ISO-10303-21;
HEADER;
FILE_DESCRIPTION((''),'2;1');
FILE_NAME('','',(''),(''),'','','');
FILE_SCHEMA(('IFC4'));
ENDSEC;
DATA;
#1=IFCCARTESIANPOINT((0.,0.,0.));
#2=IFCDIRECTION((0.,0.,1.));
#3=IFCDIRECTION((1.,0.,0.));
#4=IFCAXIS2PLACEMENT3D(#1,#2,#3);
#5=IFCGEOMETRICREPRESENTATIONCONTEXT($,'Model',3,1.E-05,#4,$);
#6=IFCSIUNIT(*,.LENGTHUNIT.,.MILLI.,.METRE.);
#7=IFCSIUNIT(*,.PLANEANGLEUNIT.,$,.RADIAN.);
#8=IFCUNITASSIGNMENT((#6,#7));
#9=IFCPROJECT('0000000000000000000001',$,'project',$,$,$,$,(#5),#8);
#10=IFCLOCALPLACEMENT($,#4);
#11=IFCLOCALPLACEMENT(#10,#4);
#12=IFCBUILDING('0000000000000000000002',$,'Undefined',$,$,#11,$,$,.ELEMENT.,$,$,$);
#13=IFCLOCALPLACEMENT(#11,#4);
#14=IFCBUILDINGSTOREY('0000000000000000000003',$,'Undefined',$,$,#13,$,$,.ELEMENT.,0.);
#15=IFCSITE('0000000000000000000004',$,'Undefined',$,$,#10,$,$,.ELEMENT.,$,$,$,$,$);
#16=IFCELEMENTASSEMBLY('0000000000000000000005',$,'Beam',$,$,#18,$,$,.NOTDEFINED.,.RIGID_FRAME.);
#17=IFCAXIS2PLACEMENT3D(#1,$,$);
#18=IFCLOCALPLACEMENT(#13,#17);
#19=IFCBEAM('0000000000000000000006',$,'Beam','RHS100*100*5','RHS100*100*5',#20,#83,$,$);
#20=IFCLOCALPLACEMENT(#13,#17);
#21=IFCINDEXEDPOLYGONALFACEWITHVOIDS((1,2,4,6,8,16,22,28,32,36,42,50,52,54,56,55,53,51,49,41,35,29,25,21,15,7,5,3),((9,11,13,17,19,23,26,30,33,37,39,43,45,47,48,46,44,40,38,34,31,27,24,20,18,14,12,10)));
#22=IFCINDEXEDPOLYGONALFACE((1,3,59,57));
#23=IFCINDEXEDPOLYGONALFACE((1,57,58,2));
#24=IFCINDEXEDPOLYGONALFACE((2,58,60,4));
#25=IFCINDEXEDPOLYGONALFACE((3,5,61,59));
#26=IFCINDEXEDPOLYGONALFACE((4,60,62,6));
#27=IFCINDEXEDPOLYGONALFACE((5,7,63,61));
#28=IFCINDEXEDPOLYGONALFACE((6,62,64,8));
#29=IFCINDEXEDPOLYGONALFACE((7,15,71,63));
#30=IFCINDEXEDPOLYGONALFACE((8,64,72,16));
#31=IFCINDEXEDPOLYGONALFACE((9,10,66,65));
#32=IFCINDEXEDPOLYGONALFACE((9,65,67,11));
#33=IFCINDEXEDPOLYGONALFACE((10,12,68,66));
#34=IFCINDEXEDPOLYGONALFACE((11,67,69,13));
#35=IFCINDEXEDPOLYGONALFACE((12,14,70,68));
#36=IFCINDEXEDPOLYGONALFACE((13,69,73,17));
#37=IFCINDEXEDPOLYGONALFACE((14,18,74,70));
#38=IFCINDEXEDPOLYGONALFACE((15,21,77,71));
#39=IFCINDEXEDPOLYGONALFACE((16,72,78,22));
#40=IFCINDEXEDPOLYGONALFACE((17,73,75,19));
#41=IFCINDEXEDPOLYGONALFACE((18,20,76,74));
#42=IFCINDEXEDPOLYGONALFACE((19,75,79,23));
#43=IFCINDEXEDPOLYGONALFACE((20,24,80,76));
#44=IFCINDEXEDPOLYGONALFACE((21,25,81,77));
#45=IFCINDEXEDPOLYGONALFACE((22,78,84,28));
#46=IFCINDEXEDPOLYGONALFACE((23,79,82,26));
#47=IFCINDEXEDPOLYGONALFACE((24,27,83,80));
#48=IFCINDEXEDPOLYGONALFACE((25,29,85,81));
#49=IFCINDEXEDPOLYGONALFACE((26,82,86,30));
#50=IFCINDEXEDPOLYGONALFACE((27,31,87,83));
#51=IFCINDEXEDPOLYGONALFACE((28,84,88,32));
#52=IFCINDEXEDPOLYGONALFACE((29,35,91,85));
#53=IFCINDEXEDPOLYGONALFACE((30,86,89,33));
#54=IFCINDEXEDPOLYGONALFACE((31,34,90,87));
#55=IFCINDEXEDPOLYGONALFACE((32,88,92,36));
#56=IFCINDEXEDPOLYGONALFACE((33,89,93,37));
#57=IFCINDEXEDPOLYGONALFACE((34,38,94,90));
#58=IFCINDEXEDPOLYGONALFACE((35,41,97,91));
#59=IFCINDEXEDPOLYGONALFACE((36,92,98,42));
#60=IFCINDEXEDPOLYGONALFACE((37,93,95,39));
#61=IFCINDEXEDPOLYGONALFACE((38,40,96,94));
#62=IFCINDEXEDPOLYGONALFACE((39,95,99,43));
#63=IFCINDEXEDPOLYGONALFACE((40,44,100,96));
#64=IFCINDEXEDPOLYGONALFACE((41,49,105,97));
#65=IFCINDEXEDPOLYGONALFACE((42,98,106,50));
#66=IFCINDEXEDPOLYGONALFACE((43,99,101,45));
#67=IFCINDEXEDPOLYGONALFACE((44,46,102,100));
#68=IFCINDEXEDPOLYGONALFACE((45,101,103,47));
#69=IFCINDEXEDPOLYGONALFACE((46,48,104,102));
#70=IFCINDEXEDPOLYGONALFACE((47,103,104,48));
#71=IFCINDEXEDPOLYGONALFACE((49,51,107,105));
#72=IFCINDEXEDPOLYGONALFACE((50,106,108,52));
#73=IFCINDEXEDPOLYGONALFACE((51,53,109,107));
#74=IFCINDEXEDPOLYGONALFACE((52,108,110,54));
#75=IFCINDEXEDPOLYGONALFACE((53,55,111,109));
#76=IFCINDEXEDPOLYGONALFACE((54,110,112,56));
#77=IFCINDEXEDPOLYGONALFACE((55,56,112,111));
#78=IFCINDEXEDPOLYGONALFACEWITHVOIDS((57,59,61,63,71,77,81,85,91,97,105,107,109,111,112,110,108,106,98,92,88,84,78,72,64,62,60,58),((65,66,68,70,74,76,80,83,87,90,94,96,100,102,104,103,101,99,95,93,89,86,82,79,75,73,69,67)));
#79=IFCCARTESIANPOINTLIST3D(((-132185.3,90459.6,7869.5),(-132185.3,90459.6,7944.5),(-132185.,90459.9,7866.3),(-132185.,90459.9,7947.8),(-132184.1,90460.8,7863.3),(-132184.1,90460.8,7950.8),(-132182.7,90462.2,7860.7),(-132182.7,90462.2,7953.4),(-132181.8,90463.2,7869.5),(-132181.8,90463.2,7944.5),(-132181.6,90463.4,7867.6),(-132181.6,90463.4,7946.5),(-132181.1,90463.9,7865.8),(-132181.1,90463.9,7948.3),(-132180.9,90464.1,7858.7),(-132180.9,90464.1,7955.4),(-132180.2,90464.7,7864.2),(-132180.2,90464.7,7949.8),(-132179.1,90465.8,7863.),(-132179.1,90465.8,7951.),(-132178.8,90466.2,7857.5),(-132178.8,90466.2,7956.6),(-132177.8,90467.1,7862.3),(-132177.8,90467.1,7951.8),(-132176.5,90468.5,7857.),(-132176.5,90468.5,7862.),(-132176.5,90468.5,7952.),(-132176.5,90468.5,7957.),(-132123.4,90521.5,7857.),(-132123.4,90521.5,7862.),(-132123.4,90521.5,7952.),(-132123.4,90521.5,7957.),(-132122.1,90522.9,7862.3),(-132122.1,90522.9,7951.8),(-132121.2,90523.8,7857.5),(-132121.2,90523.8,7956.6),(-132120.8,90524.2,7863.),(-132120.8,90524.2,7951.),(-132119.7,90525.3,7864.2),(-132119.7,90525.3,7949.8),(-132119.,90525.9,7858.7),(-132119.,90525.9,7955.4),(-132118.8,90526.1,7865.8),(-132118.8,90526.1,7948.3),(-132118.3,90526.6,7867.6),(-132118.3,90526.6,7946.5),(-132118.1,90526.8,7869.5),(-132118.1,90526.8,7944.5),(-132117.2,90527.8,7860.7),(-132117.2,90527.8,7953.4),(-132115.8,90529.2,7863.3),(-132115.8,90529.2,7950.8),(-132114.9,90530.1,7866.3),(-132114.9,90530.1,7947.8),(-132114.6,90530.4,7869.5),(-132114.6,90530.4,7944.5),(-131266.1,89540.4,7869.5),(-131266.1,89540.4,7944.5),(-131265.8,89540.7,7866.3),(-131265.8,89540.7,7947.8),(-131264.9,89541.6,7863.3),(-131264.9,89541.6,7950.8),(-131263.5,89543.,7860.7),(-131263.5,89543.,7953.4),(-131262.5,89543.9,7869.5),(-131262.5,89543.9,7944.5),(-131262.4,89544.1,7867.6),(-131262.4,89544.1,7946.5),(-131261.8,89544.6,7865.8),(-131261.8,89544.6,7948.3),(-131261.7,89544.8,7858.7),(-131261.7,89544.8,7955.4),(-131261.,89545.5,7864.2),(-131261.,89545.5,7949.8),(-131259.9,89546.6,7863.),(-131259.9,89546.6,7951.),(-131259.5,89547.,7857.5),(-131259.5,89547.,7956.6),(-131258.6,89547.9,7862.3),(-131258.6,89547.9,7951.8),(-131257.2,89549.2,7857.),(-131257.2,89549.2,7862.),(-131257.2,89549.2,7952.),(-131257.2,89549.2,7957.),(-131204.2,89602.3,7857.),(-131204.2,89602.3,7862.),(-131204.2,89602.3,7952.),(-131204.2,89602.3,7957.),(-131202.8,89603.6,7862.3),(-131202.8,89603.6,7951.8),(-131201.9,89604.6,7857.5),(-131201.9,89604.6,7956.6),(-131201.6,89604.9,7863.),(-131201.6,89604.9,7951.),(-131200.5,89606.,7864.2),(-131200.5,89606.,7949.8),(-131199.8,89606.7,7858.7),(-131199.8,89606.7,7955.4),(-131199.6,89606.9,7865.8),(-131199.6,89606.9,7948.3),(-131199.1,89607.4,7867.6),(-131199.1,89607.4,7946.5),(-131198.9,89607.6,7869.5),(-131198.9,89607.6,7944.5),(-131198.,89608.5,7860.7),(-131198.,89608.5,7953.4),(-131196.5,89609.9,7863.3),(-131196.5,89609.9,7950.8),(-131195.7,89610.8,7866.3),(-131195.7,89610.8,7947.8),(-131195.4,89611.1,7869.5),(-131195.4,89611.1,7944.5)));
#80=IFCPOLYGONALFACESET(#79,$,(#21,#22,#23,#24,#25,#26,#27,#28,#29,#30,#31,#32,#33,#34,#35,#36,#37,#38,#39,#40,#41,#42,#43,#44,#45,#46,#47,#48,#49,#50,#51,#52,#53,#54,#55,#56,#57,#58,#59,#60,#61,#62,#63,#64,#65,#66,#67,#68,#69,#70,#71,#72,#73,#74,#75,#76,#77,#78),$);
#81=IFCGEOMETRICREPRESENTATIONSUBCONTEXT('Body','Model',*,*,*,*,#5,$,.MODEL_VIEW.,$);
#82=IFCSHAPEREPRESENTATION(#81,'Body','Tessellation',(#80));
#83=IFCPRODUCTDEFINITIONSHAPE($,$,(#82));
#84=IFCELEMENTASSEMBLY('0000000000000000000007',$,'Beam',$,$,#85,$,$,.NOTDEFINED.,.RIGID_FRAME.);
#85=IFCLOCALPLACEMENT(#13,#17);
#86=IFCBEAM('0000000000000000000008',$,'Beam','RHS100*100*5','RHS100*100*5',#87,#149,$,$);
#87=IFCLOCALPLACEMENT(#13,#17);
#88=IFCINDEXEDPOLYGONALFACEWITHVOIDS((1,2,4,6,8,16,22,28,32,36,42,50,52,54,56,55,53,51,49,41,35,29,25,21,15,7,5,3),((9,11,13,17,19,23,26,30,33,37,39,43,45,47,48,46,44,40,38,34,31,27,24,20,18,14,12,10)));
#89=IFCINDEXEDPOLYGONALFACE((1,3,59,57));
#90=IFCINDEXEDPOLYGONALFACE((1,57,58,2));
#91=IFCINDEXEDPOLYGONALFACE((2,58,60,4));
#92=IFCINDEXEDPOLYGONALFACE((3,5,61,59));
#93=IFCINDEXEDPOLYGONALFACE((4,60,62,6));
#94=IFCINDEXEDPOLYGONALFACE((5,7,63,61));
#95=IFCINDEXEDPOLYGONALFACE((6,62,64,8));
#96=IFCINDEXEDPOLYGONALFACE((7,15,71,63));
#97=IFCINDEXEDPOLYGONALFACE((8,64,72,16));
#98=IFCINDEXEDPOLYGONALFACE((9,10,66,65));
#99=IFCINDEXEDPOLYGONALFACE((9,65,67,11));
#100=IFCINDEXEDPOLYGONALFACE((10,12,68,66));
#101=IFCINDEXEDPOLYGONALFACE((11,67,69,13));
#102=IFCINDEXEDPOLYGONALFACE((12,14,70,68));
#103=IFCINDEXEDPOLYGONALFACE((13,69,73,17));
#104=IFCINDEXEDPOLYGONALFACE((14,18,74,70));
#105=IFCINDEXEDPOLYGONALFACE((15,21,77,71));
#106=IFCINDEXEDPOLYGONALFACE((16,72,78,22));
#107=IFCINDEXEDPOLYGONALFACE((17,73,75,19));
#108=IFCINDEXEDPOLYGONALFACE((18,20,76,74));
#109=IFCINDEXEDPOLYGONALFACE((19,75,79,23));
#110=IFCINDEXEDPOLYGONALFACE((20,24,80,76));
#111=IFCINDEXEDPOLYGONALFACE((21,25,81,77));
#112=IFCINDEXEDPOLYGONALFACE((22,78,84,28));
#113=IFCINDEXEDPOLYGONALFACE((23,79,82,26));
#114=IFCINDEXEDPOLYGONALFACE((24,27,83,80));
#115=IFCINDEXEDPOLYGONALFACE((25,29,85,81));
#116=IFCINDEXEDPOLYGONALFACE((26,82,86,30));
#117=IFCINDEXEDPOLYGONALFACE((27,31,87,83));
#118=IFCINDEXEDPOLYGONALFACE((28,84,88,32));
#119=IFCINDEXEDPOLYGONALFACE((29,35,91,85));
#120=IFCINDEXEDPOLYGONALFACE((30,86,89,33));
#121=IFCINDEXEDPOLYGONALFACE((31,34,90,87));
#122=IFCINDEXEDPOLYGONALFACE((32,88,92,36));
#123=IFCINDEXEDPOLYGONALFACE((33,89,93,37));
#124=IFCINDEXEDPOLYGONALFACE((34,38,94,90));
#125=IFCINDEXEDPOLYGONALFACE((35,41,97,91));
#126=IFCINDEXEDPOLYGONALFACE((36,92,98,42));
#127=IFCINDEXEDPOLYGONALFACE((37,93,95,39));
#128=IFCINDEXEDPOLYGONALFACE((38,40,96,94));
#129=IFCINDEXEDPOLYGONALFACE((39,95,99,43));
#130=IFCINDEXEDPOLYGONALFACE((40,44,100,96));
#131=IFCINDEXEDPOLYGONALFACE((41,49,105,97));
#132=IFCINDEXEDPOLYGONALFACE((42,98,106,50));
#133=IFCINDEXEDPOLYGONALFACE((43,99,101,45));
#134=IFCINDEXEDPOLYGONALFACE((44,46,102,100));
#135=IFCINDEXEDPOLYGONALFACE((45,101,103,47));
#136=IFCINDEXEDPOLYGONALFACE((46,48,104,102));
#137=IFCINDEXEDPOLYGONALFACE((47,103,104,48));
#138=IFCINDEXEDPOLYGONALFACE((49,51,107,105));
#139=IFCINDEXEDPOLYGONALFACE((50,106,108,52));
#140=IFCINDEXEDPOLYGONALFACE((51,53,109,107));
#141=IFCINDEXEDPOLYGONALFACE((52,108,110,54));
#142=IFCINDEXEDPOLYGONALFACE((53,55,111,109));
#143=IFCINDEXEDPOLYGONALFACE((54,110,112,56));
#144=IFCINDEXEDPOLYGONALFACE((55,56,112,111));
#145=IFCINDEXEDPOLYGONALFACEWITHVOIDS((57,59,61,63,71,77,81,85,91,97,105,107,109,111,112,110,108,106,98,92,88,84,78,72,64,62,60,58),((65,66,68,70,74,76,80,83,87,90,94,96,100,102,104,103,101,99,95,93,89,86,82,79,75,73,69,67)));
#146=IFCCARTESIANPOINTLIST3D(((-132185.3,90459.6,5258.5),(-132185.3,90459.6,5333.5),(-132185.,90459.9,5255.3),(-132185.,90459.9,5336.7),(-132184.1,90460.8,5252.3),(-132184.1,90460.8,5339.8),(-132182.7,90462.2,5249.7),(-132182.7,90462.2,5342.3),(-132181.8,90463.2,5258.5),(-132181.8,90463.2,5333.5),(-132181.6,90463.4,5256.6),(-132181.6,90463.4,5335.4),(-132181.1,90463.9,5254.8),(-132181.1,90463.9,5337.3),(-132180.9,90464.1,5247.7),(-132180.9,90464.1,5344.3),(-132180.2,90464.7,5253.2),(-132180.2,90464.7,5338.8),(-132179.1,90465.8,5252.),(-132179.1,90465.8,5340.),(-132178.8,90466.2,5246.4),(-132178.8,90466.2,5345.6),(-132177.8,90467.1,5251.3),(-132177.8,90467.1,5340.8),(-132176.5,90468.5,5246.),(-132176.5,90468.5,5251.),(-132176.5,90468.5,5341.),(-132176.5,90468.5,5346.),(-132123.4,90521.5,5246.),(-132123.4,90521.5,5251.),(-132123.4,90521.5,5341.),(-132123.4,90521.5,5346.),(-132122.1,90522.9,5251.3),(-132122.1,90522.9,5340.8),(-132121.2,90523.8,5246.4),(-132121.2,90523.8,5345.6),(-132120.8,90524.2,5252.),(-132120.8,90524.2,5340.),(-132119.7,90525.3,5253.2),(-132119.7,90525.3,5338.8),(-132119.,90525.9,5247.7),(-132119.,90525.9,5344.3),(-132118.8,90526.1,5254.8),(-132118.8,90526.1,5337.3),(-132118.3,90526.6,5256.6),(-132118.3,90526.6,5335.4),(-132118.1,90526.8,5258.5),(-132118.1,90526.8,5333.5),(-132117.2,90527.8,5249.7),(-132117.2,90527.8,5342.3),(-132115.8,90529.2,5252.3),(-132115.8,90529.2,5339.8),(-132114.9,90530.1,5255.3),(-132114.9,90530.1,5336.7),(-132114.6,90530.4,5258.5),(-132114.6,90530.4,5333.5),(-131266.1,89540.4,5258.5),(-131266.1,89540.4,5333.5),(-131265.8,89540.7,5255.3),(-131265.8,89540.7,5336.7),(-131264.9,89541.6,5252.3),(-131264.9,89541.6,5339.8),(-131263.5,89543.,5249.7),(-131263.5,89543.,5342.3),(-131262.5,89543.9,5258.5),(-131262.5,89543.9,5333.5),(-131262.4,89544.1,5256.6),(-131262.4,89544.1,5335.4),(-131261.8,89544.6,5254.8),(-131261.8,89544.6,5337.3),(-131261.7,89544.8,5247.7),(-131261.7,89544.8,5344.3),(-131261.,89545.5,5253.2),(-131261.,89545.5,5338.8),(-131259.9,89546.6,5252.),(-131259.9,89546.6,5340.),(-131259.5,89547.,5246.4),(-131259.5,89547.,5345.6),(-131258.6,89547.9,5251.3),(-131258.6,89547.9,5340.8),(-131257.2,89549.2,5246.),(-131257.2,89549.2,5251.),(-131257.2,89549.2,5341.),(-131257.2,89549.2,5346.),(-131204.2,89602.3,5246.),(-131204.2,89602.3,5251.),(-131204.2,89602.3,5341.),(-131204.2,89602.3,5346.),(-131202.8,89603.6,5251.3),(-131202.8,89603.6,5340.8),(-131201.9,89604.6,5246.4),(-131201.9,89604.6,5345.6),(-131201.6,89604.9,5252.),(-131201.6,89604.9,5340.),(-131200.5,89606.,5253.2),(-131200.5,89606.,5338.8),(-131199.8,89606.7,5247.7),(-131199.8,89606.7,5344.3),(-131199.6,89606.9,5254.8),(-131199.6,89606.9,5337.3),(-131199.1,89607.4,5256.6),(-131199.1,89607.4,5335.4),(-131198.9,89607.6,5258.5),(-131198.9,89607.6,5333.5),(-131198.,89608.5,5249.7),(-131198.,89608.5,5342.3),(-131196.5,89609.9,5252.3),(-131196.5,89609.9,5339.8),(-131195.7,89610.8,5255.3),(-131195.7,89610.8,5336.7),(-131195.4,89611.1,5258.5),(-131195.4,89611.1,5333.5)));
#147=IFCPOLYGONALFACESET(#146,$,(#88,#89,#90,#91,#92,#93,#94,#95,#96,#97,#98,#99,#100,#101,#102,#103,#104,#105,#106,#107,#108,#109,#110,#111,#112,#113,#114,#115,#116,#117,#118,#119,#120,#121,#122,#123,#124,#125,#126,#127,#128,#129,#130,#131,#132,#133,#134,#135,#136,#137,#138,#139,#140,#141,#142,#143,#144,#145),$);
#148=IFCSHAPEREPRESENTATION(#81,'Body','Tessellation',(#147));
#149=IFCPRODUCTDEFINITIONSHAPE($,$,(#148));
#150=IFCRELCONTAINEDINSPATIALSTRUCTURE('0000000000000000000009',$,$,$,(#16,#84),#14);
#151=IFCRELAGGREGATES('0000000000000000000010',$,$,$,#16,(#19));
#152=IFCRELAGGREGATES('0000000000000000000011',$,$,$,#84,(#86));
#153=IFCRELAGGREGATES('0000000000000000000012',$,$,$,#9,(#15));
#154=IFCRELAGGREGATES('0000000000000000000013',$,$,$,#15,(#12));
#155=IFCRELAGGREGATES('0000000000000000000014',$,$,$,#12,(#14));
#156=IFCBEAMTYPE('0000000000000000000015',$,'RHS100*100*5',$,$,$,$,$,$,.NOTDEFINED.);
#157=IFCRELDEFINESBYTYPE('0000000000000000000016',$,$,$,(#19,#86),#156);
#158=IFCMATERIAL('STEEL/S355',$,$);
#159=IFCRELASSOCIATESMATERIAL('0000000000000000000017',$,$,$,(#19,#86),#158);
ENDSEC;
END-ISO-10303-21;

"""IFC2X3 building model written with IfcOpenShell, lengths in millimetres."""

from ifc_helpers import new_model, si_unit, frame, origin_with_axes, origin_2d_with_axis, place, context, subcontext, project, spatial, hollow_rectangle, extrude, material, type_object, element, aggregate, save


model = new_model("IFC2X3")

# Units and contexts
model_context = context("Model", 3, precision=1e-05, world=origin_with_axes())
body_context = subcontext(model_context, "Body", "Model", "MODEL_VIEW")
ifc_project = project(units=[si_unit("LENGTHUNIT", "METRE", prefix="MILLI"), si_unit("PLANEANGLEUNIT", "RADIAN")], contexts=[model_context])

# Site, building, storey
site_placement = place(None, origin_with_axes())
site = spatial("IfcSite", under=ifc_project, at=site_placement, Name="Undefined", CompositionType="ELEMENT")
building_placement = place(site_placement, origin_with_axes())
building = spatial("IfcBuilding", under=site, at=building_placement, Name="Undefined", CompositionType="ELEMENT")
storey_placement = place(building_placement, origin_with_axes())
storey = spatial("IfcBuildingStorey", under=building, at=storey_placement, Name="Undefined", CompositionType="ELEMENT", Elevation=0.0)

# Element assemblies, beams
ifc_material_1 = material(Name="STEEL/S355")
beam_type_1 = type_object("IfcBeamType", Name="RHS100*100*5", PredefinedType="NOTDEFINED")
assembly_1_placement = place(storey_placement, origin_with_axes())
assembly_1 = element("IfcElementAssembly", 1, at=assembly_1_placement, inside=storey, Name="Beam", AssemblyPlace="NOTDEFINED", PredefinedType="RIGID_FRAME")
beam_1_placement = place(assembly_1_placement, frame((-131230.7, 89575.8, 7907.0), z_axis=(0.0, 0.0, 1.0), x_axis=(-0.707107, 0.707107, 0.0)))
beam_1 = element("IfcBeam", 2, at=beam_1_placement, type_object=beam_type_1, material=ifc_material_1, Name="Beam", Description="RHS100*100*5", ObjectType="RHS100*100*5", context=body_context, shape_type="SweptSolid", body=[
    extrude(hollow_rectangle(XDim=100.0, YDim=100.0, WallThickness=5.0, InnerFilletRadius=7.5, OuterFilletRadius=12.5, at=origin_2d_with_axis()), frame((1300.0, 0.0, 0.0), z_axis=(-1.0, 0.0, 0.0), x_axis=(0.0, -1.0, 0.0)), (0.0, 0.0, 1.0), 1300.0),
])
aggregate(assembly_1, [beam_1])
assembly_2_placement = place(storey_placement, origin_with_axes())
assembly_2 = element("IfcElementAssembly", 3, at=assembly_2_placement, inside=storey, Name="Beam", AssemblyPlace="NOTDEFINED", PredefinedType="RIGID_FRAME")
beam_2_placement = place(assembly_2_placement, frame((-131230.7, 89575.8, 5296.0), z_axis=(0.0, 0.0, 1.0), x_axis=(-0.707107, 0.707107, 0.0)))
beam_2 = element("IfcBeam", 4, at=beam_2_placement, type_object=beam_type_1, material=ifc_material_1, Name="Beam", Description="RHS100*100*5", ObjectType="RHS100*100*5", context=body_context, shape_type="SweptSolid", body=[
    extrude(hollow_rectangle(XDim=100.0, YDim=100.0, WallThickness=5.0, InnerFilletRadius=7.5, OuterFilletRadius=12.5, at=origin_2d_with_axis()), frame((1300.0, 0.0, 0.0), z_axis=(-1.0, 0.0, 0.0), x_axis=(0.0, -1.0, 0.0)), (0.0, 0.0, 1.0), 1300.0),
])
aggregate(assembly_2, [beam_2])

save(model, "model.ifc")
